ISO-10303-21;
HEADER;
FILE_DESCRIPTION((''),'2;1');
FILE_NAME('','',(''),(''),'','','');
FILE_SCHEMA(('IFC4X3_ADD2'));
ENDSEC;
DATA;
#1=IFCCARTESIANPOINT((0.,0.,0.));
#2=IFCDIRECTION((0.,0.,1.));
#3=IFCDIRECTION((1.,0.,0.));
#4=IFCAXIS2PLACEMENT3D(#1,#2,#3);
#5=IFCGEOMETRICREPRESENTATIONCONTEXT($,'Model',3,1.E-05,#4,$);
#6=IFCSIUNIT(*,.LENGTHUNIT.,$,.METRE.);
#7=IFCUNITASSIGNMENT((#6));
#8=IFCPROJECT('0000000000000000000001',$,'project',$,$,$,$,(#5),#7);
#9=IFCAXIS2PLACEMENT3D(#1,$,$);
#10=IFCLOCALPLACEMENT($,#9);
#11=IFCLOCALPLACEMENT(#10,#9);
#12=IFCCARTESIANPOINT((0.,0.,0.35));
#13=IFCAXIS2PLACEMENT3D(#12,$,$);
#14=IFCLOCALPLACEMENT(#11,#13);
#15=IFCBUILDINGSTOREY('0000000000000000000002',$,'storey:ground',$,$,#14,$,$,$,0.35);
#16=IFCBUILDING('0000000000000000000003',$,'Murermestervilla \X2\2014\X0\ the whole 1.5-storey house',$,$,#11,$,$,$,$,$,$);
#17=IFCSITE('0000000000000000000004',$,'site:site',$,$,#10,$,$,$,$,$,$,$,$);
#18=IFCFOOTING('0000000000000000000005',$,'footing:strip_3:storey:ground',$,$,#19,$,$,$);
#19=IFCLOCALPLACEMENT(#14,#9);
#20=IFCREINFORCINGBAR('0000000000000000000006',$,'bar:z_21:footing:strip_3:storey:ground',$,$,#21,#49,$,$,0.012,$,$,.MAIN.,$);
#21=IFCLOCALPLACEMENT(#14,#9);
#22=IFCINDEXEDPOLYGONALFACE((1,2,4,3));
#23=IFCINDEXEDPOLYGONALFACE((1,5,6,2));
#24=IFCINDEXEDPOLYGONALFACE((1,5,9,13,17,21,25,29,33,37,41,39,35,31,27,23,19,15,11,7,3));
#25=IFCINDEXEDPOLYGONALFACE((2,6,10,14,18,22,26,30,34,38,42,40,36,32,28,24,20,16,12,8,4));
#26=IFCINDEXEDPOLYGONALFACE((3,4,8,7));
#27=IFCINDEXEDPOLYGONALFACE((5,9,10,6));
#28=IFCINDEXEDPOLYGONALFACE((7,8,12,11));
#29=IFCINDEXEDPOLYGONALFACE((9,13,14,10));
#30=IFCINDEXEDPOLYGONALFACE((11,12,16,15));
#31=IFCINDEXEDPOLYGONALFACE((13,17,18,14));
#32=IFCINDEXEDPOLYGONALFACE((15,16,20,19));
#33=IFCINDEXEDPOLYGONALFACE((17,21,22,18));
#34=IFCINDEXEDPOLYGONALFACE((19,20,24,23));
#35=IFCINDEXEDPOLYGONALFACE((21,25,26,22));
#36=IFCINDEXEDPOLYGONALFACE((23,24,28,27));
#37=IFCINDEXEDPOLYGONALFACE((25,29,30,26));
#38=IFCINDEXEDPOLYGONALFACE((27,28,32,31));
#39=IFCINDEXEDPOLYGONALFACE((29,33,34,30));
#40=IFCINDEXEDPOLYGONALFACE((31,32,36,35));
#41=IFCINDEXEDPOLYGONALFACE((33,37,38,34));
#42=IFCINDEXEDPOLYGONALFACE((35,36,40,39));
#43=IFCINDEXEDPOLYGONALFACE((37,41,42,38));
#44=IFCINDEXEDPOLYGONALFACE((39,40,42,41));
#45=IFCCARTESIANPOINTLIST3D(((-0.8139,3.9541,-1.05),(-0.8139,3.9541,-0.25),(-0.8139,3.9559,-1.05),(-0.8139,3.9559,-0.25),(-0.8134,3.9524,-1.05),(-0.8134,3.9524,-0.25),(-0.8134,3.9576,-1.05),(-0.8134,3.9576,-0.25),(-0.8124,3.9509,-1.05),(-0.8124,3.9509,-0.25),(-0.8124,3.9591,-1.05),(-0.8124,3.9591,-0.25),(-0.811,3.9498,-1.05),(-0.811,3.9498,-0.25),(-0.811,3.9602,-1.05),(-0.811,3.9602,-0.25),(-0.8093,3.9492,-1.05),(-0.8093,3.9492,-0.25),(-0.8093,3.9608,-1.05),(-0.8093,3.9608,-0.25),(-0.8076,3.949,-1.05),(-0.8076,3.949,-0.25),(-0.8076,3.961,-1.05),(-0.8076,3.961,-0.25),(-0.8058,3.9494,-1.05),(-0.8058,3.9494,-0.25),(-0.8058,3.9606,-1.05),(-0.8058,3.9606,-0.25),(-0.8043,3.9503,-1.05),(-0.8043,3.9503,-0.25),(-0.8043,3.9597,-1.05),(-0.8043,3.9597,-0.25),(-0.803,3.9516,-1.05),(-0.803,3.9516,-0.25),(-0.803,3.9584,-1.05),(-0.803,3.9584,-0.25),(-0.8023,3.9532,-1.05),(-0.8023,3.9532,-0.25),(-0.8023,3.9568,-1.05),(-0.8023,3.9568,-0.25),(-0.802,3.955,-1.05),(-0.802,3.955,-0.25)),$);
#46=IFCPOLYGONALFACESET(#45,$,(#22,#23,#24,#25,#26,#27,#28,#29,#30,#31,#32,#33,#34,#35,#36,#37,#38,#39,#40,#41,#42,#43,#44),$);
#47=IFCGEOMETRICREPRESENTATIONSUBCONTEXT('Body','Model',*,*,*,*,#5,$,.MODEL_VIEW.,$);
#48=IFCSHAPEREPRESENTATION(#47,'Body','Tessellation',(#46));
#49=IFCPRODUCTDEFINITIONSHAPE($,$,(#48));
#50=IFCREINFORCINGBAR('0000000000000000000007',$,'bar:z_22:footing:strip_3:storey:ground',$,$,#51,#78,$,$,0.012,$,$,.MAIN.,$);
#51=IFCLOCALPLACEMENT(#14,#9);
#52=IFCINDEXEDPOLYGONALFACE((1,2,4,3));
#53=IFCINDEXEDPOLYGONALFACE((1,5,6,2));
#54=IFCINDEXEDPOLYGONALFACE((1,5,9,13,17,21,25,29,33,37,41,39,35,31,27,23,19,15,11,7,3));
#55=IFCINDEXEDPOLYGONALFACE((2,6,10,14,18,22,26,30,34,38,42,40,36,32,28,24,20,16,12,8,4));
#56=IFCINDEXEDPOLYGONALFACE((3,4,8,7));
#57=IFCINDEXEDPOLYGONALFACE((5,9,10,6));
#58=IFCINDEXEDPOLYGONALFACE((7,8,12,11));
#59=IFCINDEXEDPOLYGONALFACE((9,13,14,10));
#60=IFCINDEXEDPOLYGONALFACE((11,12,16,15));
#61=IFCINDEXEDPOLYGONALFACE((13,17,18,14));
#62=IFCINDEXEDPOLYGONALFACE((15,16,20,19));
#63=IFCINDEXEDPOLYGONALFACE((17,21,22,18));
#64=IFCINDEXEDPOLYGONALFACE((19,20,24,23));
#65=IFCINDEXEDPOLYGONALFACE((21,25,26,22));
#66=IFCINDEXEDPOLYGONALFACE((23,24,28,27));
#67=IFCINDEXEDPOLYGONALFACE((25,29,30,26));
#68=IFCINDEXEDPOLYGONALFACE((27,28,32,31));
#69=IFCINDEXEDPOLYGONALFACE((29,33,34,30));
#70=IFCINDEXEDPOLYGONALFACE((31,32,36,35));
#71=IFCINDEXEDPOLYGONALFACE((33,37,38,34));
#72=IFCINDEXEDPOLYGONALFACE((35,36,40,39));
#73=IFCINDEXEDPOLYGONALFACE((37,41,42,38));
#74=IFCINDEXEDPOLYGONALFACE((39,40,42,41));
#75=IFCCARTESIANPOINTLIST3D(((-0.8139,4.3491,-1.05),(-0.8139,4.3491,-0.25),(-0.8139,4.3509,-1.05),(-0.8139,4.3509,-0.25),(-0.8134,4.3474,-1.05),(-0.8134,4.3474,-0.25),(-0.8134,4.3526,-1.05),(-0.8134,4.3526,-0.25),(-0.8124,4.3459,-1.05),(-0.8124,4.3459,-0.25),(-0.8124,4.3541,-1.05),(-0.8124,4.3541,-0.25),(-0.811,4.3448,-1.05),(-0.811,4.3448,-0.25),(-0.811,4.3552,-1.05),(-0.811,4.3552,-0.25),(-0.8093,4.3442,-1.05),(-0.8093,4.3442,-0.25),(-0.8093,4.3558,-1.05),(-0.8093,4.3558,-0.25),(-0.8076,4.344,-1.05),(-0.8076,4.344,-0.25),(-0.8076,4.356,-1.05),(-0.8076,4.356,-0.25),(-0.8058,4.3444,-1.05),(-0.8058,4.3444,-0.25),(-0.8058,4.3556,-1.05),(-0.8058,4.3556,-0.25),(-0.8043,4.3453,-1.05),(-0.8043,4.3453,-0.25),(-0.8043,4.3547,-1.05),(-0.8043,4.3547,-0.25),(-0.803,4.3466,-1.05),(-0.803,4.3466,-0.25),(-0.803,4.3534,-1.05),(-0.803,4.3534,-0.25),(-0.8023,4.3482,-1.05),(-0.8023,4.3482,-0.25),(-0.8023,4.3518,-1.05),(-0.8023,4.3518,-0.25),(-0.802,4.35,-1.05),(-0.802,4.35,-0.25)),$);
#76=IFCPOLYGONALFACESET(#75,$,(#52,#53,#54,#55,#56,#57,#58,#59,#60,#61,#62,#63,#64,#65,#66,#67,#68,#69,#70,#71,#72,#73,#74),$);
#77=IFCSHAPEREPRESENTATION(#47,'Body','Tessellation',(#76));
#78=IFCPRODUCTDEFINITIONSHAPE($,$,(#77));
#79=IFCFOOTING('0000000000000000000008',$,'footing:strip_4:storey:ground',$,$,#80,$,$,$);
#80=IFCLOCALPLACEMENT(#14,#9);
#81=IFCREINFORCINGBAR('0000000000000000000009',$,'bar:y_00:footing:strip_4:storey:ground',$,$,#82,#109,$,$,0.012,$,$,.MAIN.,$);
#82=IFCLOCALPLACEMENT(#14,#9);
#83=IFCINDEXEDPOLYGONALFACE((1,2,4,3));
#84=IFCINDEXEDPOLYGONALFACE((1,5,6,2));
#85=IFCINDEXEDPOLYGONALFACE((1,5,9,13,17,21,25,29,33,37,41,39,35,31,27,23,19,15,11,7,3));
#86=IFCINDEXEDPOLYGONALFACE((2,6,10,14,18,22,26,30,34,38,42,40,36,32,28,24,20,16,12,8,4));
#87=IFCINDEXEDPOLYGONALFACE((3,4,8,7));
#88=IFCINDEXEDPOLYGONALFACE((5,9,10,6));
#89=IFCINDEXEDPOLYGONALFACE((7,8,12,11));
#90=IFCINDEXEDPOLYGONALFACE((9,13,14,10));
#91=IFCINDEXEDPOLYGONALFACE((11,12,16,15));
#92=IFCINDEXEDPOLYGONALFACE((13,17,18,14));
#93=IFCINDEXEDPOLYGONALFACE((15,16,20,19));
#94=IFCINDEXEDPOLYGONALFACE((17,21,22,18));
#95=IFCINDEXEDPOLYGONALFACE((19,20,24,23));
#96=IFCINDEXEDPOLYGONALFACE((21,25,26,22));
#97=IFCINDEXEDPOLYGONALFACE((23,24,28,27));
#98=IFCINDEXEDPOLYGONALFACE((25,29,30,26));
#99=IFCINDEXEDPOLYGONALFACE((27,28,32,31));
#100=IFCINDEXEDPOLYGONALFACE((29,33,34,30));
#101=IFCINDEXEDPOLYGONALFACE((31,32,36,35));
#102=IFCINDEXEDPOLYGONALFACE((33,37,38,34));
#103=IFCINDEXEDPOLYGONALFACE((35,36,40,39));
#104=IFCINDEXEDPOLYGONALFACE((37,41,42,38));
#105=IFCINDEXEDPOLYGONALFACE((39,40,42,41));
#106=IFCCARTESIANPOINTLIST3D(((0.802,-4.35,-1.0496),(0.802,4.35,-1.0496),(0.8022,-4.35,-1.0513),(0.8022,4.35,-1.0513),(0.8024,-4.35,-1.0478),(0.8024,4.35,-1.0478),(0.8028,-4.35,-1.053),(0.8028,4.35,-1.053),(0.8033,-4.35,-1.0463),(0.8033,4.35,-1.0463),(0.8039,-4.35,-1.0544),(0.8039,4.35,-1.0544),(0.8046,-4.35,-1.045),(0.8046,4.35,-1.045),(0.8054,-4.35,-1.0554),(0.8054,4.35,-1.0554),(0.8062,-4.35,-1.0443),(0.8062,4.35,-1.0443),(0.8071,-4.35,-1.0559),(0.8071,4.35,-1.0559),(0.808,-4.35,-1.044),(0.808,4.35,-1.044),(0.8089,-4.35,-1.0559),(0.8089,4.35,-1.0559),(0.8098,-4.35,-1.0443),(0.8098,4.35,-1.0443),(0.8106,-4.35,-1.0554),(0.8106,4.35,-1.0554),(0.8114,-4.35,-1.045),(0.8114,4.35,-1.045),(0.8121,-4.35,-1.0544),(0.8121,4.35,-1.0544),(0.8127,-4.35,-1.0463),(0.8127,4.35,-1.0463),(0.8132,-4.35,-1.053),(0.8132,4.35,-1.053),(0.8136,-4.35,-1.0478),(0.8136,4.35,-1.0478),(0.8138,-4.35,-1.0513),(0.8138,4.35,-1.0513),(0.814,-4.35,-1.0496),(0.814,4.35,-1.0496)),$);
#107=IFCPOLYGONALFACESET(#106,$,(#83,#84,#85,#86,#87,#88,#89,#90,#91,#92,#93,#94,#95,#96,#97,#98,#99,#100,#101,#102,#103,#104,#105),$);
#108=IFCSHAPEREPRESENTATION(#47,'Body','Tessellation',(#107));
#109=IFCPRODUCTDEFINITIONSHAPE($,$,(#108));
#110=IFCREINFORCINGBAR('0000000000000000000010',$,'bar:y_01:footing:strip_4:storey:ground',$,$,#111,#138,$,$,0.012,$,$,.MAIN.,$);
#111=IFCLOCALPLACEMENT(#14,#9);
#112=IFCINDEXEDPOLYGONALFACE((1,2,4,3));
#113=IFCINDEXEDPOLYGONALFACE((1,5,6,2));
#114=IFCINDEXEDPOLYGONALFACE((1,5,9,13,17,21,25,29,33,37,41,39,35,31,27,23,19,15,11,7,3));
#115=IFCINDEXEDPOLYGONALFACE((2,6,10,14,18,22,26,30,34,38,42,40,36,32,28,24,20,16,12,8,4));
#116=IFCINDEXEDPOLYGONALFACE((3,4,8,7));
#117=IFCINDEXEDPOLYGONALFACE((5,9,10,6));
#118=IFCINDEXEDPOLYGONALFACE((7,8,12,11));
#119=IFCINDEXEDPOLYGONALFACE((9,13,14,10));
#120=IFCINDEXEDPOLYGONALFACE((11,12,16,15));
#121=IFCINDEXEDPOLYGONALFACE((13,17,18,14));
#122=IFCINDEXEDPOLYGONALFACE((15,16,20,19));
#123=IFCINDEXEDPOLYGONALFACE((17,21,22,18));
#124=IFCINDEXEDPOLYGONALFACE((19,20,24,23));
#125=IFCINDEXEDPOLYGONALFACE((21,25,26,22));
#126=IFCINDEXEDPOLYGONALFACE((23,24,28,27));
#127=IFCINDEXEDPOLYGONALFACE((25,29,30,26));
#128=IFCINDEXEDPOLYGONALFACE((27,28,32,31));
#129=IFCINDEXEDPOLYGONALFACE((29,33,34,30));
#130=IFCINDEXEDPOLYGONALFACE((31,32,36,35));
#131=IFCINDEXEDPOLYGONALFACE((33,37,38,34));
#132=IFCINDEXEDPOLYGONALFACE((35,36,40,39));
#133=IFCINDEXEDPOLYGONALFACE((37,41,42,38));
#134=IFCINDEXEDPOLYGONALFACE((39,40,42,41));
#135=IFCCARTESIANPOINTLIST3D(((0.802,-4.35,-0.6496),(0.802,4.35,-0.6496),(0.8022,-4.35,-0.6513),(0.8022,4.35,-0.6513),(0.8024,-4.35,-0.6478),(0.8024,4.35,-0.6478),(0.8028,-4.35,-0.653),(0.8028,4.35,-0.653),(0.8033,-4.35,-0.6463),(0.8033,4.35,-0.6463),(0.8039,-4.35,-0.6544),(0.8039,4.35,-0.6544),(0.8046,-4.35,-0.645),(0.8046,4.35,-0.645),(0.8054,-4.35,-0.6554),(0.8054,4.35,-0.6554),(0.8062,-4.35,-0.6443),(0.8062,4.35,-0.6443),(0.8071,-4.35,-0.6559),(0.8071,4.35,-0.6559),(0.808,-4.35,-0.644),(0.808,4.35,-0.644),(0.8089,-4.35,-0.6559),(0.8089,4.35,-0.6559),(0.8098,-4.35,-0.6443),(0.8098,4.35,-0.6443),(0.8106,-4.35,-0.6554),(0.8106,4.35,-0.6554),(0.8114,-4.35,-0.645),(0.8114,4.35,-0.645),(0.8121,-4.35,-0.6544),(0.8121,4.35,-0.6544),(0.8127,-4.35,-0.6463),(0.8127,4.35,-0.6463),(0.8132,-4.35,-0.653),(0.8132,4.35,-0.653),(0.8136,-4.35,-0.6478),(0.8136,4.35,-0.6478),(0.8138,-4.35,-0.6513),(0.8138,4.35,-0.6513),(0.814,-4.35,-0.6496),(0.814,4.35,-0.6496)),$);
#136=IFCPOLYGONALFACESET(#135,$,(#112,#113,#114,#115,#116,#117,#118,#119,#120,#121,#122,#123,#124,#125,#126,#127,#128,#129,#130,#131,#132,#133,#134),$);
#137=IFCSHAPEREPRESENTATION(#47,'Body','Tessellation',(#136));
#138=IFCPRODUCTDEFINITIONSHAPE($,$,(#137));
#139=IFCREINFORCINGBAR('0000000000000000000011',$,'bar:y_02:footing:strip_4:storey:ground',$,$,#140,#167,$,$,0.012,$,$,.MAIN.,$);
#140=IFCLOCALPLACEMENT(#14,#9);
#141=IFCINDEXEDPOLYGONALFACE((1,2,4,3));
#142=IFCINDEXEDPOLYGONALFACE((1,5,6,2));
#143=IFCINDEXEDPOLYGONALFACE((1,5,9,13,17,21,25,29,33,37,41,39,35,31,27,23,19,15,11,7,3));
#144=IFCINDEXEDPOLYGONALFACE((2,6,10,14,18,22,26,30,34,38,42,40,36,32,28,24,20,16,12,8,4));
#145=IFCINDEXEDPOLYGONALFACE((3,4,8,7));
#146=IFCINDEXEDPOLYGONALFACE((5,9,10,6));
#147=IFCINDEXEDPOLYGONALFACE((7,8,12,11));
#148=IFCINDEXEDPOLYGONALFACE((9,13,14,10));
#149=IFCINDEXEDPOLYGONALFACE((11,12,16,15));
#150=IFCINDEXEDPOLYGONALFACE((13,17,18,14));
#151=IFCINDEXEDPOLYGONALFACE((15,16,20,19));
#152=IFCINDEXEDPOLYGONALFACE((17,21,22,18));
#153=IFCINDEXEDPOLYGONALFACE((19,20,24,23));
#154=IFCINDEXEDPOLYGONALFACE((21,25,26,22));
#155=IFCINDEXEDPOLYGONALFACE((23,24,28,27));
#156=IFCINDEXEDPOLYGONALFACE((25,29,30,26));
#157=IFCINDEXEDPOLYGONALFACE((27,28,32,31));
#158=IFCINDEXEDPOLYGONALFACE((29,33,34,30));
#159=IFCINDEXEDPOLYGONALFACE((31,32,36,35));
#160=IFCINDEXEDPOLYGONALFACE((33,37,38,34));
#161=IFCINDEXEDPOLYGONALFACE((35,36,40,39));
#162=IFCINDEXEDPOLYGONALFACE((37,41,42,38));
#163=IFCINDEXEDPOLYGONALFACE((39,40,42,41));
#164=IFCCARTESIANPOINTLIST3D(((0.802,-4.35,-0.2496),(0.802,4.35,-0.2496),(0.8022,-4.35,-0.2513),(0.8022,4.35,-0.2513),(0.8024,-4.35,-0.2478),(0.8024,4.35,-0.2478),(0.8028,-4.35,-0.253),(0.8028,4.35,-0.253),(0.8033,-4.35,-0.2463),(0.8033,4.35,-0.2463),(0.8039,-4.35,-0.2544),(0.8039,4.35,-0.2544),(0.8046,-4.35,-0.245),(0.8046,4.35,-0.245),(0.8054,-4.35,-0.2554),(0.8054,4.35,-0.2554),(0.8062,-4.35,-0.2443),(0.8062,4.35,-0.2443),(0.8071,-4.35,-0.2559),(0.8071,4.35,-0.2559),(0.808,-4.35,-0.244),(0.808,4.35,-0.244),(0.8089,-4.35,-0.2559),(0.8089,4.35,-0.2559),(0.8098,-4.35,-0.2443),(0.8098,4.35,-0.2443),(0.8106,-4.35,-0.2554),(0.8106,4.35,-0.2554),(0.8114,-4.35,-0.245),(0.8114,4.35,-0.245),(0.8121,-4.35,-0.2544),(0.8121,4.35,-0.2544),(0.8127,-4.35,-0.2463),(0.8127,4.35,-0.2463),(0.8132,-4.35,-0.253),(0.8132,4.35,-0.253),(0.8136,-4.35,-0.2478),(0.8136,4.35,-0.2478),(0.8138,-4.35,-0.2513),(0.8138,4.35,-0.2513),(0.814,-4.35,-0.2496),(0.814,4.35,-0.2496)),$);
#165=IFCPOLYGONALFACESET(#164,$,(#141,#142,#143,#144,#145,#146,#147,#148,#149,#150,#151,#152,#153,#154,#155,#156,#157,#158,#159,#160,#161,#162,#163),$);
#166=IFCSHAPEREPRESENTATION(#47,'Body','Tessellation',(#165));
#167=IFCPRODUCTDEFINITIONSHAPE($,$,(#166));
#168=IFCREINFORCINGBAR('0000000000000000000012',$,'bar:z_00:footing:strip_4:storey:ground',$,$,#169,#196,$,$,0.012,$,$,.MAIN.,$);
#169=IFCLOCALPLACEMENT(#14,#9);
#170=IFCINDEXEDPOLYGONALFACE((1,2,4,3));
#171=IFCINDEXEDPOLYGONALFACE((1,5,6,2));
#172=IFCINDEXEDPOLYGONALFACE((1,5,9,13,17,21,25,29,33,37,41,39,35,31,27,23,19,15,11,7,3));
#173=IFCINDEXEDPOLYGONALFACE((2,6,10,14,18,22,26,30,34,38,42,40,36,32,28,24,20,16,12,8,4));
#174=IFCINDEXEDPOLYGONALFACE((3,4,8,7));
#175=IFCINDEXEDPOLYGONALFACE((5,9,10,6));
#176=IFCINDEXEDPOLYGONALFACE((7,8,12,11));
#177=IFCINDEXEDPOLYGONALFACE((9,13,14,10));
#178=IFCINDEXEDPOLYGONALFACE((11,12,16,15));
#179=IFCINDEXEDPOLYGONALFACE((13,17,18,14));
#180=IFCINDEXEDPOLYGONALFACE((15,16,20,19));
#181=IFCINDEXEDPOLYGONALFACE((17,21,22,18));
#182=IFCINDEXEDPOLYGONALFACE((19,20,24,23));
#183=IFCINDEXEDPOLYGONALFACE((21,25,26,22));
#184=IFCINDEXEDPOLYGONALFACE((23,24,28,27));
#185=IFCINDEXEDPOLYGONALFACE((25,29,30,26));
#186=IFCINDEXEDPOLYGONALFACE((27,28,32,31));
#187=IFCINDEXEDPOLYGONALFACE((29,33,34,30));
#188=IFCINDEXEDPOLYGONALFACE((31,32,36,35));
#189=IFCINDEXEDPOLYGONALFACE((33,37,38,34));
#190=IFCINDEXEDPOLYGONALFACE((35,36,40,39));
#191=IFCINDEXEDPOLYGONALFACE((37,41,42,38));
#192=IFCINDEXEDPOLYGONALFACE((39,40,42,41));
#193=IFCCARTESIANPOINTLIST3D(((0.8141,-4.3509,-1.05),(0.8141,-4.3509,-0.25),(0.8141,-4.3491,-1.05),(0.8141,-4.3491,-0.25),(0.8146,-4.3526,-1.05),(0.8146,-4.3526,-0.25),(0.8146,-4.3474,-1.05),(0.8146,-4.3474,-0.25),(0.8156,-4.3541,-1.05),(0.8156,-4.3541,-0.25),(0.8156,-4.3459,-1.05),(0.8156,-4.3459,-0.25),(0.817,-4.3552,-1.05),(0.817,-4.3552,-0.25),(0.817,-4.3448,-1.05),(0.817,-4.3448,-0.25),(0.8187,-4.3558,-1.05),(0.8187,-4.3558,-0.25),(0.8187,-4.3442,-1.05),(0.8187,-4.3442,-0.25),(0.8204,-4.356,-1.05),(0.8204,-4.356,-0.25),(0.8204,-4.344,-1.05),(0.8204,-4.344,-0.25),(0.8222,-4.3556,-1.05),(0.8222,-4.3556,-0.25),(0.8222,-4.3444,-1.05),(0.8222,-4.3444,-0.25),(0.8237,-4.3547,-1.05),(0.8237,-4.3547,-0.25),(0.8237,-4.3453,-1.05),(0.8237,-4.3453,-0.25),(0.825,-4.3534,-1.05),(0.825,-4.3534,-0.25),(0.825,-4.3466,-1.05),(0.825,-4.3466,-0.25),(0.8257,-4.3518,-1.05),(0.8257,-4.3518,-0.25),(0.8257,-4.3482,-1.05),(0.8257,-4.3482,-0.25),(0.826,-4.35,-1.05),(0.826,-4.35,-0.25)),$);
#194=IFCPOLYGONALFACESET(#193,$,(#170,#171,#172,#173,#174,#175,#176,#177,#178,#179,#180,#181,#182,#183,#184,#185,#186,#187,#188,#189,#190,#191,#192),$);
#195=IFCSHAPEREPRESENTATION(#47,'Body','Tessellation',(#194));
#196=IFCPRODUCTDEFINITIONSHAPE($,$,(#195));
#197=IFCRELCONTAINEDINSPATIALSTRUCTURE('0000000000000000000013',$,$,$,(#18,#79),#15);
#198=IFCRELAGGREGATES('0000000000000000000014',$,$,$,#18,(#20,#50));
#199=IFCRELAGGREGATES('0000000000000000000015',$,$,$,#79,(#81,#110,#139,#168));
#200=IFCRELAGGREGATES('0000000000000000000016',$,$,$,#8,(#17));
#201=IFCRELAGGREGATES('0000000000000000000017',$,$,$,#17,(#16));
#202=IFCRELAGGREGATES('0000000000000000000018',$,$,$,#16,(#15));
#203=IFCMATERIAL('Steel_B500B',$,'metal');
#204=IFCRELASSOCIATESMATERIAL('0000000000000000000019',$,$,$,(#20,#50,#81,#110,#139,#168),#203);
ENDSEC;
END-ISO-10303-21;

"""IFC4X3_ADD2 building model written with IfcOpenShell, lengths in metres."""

from ifc_helpers import new_model, entity, si_unit, frame, origin, origin_with_axes, place, context, subcontext, project, spatial, material, element, aggregate, save


model = new_model("IFC4X3_ADD2")

# Units and contexts
model_context = context("Model", 3, precision=1e-05, world=origin_with_axes())
body_context = subcontext(model_context, "Body", "Model", "MODEL_VIEW")
ifc_project = project(units=[si_unit("LENGTHUNIT", "METRE")], contexts=[model_context])

# Site, building, storey
placement_1 = place(None, origin())
site = spatial("IfcSite", under=ifc_project, at=placement_1, Name="site:site")
building_placement = place(placement_1, origin())
building = spatial("IfcBuilding", under=site, at=building_placement, Name="Murermestervilla — the whole 1.5-storey house")
storey_placement = place(building_placement, frame((0.0, 0.0, 0.35)))
storey = spatial("IfcBuildingStorey", under=building, at=storey_placement, Name="storey:ground", Elevation=0.35)

# Footings, reinforcing bars
placement_2 = place(storey_placement, frame((0.0, 0.0, -0.35)))
footing_1 = element("IfcFooting", 1, at=placement_2, inside=storey, Name="footing:strip_3:storey:ground")
ifc_material = material(Name="Steel_B500B", Category="metal")
reinforcing_bar_1 = element("IfcReinforcingBar", 2, at=placement_1, material=ifc_material, Name="bar:z_21:footing:strip_3:storey:ground", NominalDiameter=0.012, PredefinedType="MAIN", context=body_context, shape_type="AdvancedSweptSolid", body=[
    entity("IfcSweptDiskSolid", entity("IfcPolyline", [entity("IfcCartesianPoint", [-0.808, 3.955, -0.7]), entity("IfcCartesianPoint", [-0.808, 3.955, 0.1])]), 0.006),
])
reinforcing_bar_2 = element("IfcReinforcingBar", 3, at=placement_1, material=ifc_material, Name="bar:z_22:footing:strip_3:storey:ground", NominalDiameter=0.012, PredefinedType="MAIN", context=body_context, shape_type="AdvancedSweptSolid", body=[
    entity("IfcSweptDiskSolid", entity("IfcPolyline", [entity("IfcCartesianPoint", [-0.808, 4.35, -0.7]), entity("IfcCartesianPoint", [-0.808, 4.35, 0.1])]), 0.006),
])
aggregate(footing_1, [reinforcing_bar_1, reinforcing_bar_2])
footing_2 = element("IfcFooting", 4, at=placement_2, inside=storey, Name="footing:strip_4:storey:ground")
reinforcing_bar_3 = element("IfcReinforcingBar", 5, at=placement_1, material=ifc_material, Name="bar:y_00:footing:strip_4:storey:ground", NominalDiameter=0.012, PredefinedType="MAIN", context=body_context, shape_type="AdvancedSweptSolid", body=[
    entity("IfcSweptDiskSolid", entity("IfcPolyline", [entity("IfcCartesianPoint", [0.808, -4.35, -0.7]), entity("IfcCartesianPoint", [0.808, 4.35, -0.7])]), 0.006),
])
reinforcing_bar_4 = element("IfcReinforcingBar", 6, at=placement_1, material=ifc_material, Name="bar:y_01:footing:strip_4:storey:ground", NominalDiameter=0.012, PredefinedType="MAIN", context=body_context, shape_type="AdvancedSweptSolid", body=[
    entity("IfcSweptDiskSolid", entity("IfcPolyline", [entity("IfcCartesianPoint", [0.808, -4.35, -0.3]), entity("IfcCartesianPoint", [0.808, 4.35, -0.3])]), 0.006),
])
reinforcing_bar_5 = element("IfcReinforcingBar", 7, at=placement_1, material=ifc_material, Name="bar:y_02:footing:strip_4:storey:ground", NominalDiameter=0.012, PredefinedType="MAIN", context=body_context, shape_type="AdvancedSweptSolid", body=[
    entity("IfcSweptDiskSolid", entity("IfcPolyline", [entity("IfcCartesianPoint", [0.808, -4.35, 0.1]), entity("IfcCartesianPoint", [0.808, 4.35, 0.1])]), 0.006),
])
reinforcing_bar_6 = element("IfcReinforcingBar", 8, at=placement_1, material=ifc_material, Name="bar:z_00:footing:strip_4:storey:ground", NominalDiameter=0.012, PredefinedType="MAIN", context=body_context, shape_type="AdvancedSweptSolid", body=[
    entity("IfcSweptDiskSolid", entity("IfcPolyline", [entity("IfcCartesianPoint", [0.82, -4.35, -0.7]), entity("IfcCartesianPoint", [0.82, -4.35, 0.1])]), 0.006),
])
aggregate(footing_2, [reinforcing_bar_3, reinforcing_bar_4, reinforcing_bar_5, reinforcing_bar_6])

save(model, "model.ifc")
